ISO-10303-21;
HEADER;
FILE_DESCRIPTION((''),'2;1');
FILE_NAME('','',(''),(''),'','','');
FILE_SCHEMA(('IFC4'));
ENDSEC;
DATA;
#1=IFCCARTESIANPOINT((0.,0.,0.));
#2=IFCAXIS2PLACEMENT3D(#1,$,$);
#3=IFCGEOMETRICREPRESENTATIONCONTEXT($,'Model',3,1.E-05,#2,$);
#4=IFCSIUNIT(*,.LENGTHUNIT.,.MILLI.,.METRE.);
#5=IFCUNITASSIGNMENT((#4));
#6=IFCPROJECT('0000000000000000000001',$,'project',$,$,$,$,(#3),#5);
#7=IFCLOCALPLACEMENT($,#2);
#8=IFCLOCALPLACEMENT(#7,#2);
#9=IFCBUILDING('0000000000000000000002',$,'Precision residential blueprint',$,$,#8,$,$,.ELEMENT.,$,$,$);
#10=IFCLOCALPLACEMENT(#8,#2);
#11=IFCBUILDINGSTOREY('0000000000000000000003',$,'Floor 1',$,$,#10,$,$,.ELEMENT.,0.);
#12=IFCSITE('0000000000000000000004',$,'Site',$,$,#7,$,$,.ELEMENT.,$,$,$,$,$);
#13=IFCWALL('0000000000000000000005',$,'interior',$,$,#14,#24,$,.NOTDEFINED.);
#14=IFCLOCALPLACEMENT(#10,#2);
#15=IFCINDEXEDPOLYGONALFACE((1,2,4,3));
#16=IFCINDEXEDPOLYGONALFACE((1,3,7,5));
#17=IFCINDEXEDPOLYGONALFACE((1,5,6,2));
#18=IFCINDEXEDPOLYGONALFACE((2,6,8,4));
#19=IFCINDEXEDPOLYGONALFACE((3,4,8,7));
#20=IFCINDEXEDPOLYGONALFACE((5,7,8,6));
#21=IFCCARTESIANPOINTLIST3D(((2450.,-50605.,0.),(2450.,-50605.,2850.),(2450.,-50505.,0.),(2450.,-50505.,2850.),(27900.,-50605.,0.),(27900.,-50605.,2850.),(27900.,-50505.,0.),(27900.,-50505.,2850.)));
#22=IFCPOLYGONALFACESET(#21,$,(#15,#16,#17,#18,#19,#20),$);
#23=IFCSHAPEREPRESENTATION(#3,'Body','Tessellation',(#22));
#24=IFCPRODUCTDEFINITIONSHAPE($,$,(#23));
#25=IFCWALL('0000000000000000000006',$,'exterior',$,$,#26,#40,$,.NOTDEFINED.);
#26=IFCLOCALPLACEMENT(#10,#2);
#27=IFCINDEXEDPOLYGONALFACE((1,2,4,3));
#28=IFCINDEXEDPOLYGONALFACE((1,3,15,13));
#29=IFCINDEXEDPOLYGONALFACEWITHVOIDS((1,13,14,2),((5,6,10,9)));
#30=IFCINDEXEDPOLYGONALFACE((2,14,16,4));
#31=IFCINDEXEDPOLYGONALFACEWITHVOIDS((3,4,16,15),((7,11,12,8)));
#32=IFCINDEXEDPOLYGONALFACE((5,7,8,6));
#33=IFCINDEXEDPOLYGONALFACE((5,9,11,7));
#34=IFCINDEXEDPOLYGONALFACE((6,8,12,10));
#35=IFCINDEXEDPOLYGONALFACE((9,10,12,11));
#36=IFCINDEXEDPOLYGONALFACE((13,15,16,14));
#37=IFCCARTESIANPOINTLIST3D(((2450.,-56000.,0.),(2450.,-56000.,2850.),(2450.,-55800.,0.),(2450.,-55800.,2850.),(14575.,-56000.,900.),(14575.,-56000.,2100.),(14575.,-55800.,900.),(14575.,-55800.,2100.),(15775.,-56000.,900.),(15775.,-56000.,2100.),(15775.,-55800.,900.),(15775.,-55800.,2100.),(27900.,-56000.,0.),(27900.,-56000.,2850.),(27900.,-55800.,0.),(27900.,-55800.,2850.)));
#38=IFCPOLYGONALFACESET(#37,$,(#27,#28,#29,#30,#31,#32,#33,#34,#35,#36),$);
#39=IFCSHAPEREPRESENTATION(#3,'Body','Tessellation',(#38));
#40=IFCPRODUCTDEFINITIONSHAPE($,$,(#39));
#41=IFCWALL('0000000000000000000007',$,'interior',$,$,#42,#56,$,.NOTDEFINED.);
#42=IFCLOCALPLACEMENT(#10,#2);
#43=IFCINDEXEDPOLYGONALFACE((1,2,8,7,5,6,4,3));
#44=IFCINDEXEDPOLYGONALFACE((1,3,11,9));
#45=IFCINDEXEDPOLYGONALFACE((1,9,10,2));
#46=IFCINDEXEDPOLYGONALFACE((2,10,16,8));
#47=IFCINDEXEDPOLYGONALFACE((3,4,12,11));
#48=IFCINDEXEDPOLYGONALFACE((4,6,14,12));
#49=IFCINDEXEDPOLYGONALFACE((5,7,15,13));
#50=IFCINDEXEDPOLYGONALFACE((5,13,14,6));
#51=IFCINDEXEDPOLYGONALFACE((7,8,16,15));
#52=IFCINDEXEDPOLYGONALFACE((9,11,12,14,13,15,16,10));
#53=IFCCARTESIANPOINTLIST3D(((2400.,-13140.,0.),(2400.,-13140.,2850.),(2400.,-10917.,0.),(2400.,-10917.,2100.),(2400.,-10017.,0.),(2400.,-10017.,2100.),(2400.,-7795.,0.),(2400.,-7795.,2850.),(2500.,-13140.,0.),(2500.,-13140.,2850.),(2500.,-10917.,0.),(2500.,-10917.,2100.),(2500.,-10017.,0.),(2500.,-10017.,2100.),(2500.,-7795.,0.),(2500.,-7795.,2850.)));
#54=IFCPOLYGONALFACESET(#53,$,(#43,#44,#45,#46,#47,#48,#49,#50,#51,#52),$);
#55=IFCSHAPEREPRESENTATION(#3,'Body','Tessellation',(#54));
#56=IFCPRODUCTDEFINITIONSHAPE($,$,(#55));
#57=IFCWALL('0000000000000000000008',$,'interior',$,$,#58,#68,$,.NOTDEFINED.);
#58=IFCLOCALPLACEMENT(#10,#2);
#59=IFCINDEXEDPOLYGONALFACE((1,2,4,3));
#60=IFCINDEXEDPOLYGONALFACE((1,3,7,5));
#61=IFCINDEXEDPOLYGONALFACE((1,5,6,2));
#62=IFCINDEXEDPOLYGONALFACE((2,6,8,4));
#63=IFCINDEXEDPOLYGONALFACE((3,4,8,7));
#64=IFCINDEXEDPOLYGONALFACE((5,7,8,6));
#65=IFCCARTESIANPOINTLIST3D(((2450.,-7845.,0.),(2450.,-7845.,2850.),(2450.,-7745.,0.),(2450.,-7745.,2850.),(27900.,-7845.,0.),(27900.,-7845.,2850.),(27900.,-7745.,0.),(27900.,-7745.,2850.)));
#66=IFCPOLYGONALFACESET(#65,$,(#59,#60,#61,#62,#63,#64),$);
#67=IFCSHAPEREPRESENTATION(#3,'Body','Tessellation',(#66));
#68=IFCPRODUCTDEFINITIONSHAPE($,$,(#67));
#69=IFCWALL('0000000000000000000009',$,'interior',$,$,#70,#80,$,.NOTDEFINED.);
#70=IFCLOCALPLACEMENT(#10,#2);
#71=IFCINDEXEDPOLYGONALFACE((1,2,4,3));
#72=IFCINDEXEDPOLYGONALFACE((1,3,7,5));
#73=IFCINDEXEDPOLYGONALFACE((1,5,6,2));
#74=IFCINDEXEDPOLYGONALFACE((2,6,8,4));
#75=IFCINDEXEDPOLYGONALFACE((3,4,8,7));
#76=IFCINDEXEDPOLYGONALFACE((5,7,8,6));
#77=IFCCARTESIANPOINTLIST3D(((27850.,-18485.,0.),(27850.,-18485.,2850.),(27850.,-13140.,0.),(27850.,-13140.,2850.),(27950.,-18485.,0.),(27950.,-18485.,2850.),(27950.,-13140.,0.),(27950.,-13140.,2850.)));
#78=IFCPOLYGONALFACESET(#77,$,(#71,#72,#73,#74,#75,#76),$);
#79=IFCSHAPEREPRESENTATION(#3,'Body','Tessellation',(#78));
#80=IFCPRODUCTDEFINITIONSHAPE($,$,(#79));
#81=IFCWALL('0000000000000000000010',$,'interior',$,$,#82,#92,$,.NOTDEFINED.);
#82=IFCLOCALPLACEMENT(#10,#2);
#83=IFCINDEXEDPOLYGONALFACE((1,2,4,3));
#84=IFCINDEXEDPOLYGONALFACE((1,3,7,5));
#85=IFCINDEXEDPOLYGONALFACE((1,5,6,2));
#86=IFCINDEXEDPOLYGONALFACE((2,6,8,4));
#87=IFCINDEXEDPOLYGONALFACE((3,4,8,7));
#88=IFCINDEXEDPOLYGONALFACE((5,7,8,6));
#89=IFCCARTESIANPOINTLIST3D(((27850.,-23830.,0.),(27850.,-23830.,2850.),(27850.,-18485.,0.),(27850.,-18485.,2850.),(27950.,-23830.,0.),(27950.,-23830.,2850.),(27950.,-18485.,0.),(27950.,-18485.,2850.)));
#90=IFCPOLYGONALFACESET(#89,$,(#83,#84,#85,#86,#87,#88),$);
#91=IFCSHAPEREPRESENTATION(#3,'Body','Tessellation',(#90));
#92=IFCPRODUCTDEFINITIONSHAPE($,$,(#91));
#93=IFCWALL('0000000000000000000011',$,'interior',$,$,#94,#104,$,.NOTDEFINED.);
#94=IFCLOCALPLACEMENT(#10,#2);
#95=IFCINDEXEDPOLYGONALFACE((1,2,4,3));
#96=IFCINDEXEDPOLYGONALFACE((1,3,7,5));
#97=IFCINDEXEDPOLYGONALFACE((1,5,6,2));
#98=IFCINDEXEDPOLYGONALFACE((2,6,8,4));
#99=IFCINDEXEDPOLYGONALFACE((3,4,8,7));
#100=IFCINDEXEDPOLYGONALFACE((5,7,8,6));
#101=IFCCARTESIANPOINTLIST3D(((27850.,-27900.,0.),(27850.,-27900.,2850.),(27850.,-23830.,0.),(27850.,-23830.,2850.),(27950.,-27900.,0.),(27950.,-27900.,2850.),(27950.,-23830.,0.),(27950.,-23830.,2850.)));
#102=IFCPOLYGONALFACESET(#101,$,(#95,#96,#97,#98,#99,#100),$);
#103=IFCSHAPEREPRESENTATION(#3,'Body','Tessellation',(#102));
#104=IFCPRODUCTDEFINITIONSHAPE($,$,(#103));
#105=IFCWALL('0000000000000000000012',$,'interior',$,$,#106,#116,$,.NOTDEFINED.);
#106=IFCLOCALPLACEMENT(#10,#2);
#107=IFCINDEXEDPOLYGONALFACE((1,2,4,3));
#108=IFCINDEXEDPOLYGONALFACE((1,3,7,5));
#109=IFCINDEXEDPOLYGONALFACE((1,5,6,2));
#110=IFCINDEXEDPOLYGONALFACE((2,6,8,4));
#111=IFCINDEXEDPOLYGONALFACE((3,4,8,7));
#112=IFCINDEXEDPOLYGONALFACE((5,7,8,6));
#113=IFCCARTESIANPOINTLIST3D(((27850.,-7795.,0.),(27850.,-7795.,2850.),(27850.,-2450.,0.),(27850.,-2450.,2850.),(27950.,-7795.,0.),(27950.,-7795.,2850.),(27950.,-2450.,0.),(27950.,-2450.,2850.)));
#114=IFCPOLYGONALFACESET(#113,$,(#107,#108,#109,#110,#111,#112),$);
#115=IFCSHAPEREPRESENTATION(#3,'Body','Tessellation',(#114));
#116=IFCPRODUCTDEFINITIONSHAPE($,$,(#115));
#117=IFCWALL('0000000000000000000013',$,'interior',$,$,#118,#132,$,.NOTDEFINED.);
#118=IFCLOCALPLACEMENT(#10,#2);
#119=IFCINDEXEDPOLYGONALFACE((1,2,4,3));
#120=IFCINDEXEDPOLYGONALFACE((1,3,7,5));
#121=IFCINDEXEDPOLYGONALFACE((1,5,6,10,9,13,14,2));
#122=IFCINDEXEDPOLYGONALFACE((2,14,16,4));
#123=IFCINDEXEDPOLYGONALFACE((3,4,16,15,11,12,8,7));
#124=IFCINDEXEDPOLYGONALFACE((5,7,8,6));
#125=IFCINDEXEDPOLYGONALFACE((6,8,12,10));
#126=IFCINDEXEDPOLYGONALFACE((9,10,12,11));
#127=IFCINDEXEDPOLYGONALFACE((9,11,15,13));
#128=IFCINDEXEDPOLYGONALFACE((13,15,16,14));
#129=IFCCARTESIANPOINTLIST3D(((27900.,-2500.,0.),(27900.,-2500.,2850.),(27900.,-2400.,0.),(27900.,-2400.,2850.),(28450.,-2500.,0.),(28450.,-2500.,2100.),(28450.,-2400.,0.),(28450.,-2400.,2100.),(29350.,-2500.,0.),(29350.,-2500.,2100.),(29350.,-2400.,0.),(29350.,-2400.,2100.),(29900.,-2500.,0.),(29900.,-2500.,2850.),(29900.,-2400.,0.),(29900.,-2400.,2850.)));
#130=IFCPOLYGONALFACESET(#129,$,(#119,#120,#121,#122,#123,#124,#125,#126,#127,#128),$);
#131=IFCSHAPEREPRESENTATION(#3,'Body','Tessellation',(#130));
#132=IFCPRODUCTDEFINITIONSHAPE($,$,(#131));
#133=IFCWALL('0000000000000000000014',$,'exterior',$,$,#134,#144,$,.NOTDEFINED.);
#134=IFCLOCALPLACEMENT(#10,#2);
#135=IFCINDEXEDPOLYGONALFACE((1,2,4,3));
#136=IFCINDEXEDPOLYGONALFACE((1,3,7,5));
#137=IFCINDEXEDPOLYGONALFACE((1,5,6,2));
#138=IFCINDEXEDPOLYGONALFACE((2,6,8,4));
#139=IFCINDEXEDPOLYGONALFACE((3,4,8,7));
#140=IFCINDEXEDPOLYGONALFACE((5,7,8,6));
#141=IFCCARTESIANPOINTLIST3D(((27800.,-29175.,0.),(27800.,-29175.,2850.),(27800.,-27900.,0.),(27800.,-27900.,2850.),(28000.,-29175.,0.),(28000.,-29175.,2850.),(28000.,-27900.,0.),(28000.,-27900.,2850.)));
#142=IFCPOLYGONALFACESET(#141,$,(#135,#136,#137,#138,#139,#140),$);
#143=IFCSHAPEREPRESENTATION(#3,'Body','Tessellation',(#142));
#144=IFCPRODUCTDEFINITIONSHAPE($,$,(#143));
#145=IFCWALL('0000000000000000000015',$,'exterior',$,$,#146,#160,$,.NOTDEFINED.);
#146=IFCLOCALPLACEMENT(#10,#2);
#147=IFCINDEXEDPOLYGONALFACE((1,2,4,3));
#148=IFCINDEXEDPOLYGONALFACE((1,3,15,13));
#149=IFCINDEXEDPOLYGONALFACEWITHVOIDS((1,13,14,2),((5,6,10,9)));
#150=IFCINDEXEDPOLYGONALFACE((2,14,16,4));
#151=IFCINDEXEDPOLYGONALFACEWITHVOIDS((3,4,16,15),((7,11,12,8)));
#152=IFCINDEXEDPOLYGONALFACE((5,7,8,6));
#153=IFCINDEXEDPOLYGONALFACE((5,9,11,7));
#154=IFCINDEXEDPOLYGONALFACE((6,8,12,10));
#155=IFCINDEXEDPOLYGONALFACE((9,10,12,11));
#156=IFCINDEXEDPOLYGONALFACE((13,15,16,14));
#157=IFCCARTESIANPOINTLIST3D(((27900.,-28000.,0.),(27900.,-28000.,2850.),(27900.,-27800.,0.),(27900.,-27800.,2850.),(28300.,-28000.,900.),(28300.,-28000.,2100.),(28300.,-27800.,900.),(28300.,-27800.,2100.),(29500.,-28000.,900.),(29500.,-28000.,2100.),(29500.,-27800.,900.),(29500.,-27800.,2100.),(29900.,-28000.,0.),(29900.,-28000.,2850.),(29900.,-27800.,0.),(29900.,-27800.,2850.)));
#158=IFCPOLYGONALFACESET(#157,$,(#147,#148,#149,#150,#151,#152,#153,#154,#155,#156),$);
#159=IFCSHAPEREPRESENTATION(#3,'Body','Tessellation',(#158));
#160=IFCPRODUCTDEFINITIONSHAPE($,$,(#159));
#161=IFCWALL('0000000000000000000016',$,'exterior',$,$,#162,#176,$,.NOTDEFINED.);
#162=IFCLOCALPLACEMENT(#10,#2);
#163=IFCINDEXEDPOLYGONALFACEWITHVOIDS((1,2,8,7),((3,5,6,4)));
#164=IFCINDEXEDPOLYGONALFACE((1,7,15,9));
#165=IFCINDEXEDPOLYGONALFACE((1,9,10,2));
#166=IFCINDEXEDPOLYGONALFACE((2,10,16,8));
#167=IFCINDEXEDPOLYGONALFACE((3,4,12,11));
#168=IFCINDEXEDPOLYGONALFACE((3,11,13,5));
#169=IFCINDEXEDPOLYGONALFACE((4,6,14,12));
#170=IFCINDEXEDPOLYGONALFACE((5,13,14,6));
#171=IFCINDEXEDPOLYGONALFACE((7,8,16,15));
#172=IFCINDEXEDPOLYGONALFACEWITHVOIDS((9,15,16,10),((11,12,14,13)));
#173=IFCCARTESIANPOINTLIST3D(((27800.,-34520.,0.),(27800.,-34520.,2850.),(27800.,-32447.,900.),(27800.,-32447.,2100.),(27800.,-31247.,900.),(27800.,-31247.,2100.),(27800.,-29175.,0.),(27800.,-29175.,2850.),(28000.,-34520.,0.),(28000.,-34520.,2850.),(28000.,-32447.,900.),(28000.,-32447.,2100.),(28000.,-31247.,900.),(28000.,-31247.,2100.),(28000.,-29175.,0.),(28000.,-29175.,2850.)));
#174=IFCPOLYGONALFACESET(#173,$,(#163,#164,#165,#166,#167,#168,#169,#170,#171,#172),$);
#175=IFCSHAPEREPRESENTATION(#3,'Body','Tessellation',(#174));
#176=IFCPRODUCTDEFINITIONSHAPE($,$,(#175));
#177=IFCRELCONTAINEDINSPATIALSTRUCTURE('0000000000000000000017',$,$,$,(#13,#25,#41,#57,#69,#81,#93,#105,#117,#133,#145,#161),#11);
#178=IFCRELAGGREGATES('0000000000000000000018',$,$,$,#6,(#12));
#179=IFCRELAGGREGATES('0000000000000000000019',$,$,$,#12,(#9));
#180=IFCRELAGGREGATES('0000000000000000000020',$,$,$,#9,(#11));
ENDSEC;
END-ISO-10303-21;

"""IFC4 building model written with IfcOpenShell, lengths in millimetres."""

from ifc_helpers import new_model, si_unit, frame, origin, place, context, project, spatial, polyline, outline, extrude, element, save


model = new_model("IFC4")

# Units and contexts
model_context = context("Model", 3, precision=1e-05, world=origin())
ifc_project = project(units=[si_unit("LENGTHUNIT", "METRE", prefix="MILLI")], contexts=[model_context])

# Site, building, storey
site_placement = place(None, origin())
site = spatial("IfcSite", under=ifc_project, at=site_placement, Name="Site", CompositionType="ELEMENT")
building_placement = place(site_placement, origin())
building = spatial("IfcBuilding", under=site, at=building_placement, Name="Precision residential blueprint", CompositionType="ELEMENT")
storey_placement = place(building_placement, origin())
storey = spatial("IfcBuildingStorey", under=building, at=storey_placement, Name="Floor 1", CompositionType="ELEMENT", Elevation=0.0)

# Wall
wall_1_placement = place(storey_placement, origin())
element("IfcWall", 1, at=wall_1_placement, inside=storey, Name="interior", PredefinedType="NOTDEFINED", context=model_context, shape_type="SweptSolid", body=[
    extrude(outline(polyline([(2450.0, -50505.0), (27900.0, -50505.0), (27900.0, -50605.0), (2450.0, -50605.0), (2450.0, -50505.0)])), origin(), (0.0, 0.0, 1.0), 2850.0),
])

# Walls, openings
wall_2_placement = place(storey_placement, origin())
wall_2 = element("IfcWall", 2, at=wall_2_placement, inside=storey, Name="exterior", PredefinedType="NOTDEFINED", context=model_context, shape_type="SweptSolid", body=[
    extrude(outline(polyline([(2450.0, -55800.0), (27900.0, -55800.0), (27900.0, -56000.0), (2450.0, -56000.0), (2450.0, -55800.0)])), origin(), (0.0, 0.0, 1.0), 2850.0),
])
opening_1_placement = place(storey_placement, origin())
element("IfcOpeningElement", 3, at=opening_1_placement, cuts=wall_2, PredefinedType="OPENING", context=model_context, shape_type="SweptSolid", body=[
    extrude(outline(polyline([(14575.0, -55800.0), (15775.0, -55800.0), (15775.0, -56000.0), (14575.0, -56000.0), (14575.0, -55800.0)])), frame((0.0, 0.0, 900.0)), (0.0, 0.0, 1.0), 1200.0),
])
wall_3_placement = place(storey_placement, origin())
wall_3 = element("IfcWall", 4, at=wall_3_placement, inside=storey, Name="interior", PredefinedType="NOTDEFINED", context=model_context, shape_type="SweptSolid", body=[
    extrude(outline(polyline([(2500.0, -7795.0), (2500.0, -13140.0), (2400.0, -13140.0), (2400.0, -7795.0), (2500.0, -7795.0)])), origin(), (0.0, 0.0, 1.0), 2850.0),
])
opening_2_placement = place(storey_placement, origin())
element("IfcOpeningElement", 5, at=opening_2_placement, cuts=wall_3, PredefinedType="OPENING", context=model_context, shape_type="SweptSolid", body=[
    extrude(outline(polyline([(2500.0, -10017.0), (2500.0, -10917.0), (2400.0, -10917.0), (2400.0, -10017.0), (2500.0, -10017.0)])), origin(), (0.0, 0.0, 1.0), 2100.0),
])

# Walls
wall_4_placement = place(storey_placement, origin())
element("IfcWall", 6, at=wall_4_placement, inside=storey, Name="interior", PredefinedType="NOTDEFINED", context=model_context, shape_type="SweptSolid", body=[
    extrude(outline(polyline([(2450.0, -7745.0), (27900.0, -7745.0), (27900.0, -7845.0), (2450.0, -7845.0), (2450.0, -7745.0)])), origin(), (0.0, 0.0, 1.0), 2850.0),
])
wall_5_placement = place(storey_placement, origin())
element("IfcWall", 7, at=wall_5_placement, inside=storey, Name="interior", PredefinedType="NOTDEFINED", context=model_context, shape_type="SweptSolid", body=[
    extrude(outline(polyline([(27950.0, -13140.0), (27950.0, -18485.0), (27850.0, -18485.0), (27850.0, -13140.0), (27950.0, -13140.0)])), origin(), (0.0, 0.0, 1.0), 2850.0),
])
wall_6_placement = place(storey_placement, origin())
element("IfcWall", 8, at=wall_6_placement, inside=storey, Name="interior", PredefinedType="NOTDEFINED", context=model_context, shape_type="SweptSolid", body=[
    extrude(outline(polyline([(27950.0, -18485.0), (27950.0, -23830.0), (27850.0, -23830.0), (27850.0, -18485.0), (27950.0, -18485.0)])), origin(), (0.0, 0.0, 1.0), 2850.0),
])
wall_7_placement = place(storey_placement, origin())
element("IfcWall", 9, at=wall_7_placement, inside=storey, Name="interior", PredefinedType="NOTDEFINED", context=model_context, shape_type="SweptSolid", body=[
    extrude(outline(polyline([(27950.0, -23830.0), (27950.0, -27900.0), (27850.0, -27900.0), (27850.0, -23830.0), (27950.0, -23830.0)])), origin(), (0.0, 0.0, 1.0), 2850.0),
])
wall_8_placement = place(storey_placement, origin())
element("IfcWall", 10, at=wall_8_placement, inside=storey, Name="interior", PredefinedType="NOTDEFINED", context=model_context, shape_type="SweptSolid", body=[
    extrude(outline(polyline([(27950.0, -2450.0), (27950.0, -7795.0), (27850.0, -7795.0), (27850.0, -2450.0), (27950.0, -2450.0)])), origin(), (0.0, 0.0, 1.0), 2850.0),
])

# Wall, opening
wall_9_placement = place(storey_placement, origin())
wall_9 = element("IfcWall", 11, at=wall_9_placement, inside=storey, Name="interior", PredefinedType="NOTDEFINED", context=model_context, shape_type="SweptSolid", body=[
    extrude(outline(polyline([(27900.0, -2400.0), (29900.0, -2400.0), (29900.0, -2500.0), (27900.0, -2500.0), (27900.0, -2400.0)])), origin(), (0.0, 0.0, 1.0), 2850.0),
])
opening_3_placement = place(storey_placement, origin())
element("IfcOpeningElement", 12, at=opening_3_placement, cuts=wall_9, PredefinedType="OPENING", context=model_context, shape_type="SweptSolid", body=[
    extrude(outline(polyline([(28450.0, -2400.0), (29350.0, -2400.0), (29350.0, -2500.0), (28450.0, -2500.0), (28450.0, -2400.0)])), origin(), (0.0, 0.0, 1.0), 2100.0),
])

# Wall
wall_10_placement = place(storey_placement, origin())
element("IfcWall", 13, at=wall_10_placement, inside=storey, Name="exterior", PredefinedType="NOTDEFINED", context=model_context, shape_type="SweptSolid", body=[
    extrude(outline(polyline([(28000.0, -27900.0), (28000.0, -29175.0), (27800.0, -29175.0), (27800.0, -27900.0), (28000.0, -27900.0)])), origin(), (0.0, 0.0, 1.0), 2850.0),
])

# Walls, openings
wall_11_placement = place(storey_placement, origin())
wall_11 = element("IfcWall", 14, at=wall_11_placement, inside=storey, Name="exterior", PredefinedType="NOTDEFINED", context=model_context, shape_type="SweptSolid", body=[
    extrude(outline(polyline([(27900.0, -27800.0), (29900.0, -27800.0), (29900.0, -28000.0), (27900.0, -28000.0), (27900.0, -27800.0)])), origin(), (0.0, 0.0, 1.0), 2850.0),
])
opening_4_placement = place(storey_placement, origin())
element("IfcOpeningElement", 15, at=opening_4_placement, cuts=wall_11, PredefinedType="OPENING", context=model_context, shape_type="SweptSolid", body=[
    extrude(outline(polyline([(28300.0, -27800.0), (29500.0, -27800.0), (29500.0, -28000.0), (28300.0, -28000.0), (28300.0, -27800.0)])), frame((0.0, 0.0, 900.0)), (0.0, 0.0, 1.0), 1200.0),
])
wall_12_placement = place(storey_placement, origin())
wall_12 = element("IfcWall", 16, at=wall_12_placement, inside=storey, Name="exterior", PredefinedType="NOTDEFINED", context=model_context, shape_type="SweptSolid", body=[
    extrude(outline(polyline([(28000.0, -29175.0), (28000.0, -34520.0), (27800.0, -34520.0), (27800.0, -29175.0), (28000.0, -29175.0)])), origin(), (0.0, 0.0, 1.0), 2850.0),
])
opening_5_placement = place(storey_placement, origin())
element("IfcOpeningElement", 17, at=opening_5_placement, cuts=wall_12, PredefinedType="OPENING", context=model_context, shape_type="SweptSolid", body=[
    extrude(outline(polyline([(28000.0, -31247.0), (28000.0, -32447.0), (27800.0, -32447.0), (27800.0, -31247.0), (28000.0, -31247.0)])), frame((0.0, 0.0, 900.0)), (0.0, 0.0, 1.0), 1200.0),
])

save(model, "model.ifc")
